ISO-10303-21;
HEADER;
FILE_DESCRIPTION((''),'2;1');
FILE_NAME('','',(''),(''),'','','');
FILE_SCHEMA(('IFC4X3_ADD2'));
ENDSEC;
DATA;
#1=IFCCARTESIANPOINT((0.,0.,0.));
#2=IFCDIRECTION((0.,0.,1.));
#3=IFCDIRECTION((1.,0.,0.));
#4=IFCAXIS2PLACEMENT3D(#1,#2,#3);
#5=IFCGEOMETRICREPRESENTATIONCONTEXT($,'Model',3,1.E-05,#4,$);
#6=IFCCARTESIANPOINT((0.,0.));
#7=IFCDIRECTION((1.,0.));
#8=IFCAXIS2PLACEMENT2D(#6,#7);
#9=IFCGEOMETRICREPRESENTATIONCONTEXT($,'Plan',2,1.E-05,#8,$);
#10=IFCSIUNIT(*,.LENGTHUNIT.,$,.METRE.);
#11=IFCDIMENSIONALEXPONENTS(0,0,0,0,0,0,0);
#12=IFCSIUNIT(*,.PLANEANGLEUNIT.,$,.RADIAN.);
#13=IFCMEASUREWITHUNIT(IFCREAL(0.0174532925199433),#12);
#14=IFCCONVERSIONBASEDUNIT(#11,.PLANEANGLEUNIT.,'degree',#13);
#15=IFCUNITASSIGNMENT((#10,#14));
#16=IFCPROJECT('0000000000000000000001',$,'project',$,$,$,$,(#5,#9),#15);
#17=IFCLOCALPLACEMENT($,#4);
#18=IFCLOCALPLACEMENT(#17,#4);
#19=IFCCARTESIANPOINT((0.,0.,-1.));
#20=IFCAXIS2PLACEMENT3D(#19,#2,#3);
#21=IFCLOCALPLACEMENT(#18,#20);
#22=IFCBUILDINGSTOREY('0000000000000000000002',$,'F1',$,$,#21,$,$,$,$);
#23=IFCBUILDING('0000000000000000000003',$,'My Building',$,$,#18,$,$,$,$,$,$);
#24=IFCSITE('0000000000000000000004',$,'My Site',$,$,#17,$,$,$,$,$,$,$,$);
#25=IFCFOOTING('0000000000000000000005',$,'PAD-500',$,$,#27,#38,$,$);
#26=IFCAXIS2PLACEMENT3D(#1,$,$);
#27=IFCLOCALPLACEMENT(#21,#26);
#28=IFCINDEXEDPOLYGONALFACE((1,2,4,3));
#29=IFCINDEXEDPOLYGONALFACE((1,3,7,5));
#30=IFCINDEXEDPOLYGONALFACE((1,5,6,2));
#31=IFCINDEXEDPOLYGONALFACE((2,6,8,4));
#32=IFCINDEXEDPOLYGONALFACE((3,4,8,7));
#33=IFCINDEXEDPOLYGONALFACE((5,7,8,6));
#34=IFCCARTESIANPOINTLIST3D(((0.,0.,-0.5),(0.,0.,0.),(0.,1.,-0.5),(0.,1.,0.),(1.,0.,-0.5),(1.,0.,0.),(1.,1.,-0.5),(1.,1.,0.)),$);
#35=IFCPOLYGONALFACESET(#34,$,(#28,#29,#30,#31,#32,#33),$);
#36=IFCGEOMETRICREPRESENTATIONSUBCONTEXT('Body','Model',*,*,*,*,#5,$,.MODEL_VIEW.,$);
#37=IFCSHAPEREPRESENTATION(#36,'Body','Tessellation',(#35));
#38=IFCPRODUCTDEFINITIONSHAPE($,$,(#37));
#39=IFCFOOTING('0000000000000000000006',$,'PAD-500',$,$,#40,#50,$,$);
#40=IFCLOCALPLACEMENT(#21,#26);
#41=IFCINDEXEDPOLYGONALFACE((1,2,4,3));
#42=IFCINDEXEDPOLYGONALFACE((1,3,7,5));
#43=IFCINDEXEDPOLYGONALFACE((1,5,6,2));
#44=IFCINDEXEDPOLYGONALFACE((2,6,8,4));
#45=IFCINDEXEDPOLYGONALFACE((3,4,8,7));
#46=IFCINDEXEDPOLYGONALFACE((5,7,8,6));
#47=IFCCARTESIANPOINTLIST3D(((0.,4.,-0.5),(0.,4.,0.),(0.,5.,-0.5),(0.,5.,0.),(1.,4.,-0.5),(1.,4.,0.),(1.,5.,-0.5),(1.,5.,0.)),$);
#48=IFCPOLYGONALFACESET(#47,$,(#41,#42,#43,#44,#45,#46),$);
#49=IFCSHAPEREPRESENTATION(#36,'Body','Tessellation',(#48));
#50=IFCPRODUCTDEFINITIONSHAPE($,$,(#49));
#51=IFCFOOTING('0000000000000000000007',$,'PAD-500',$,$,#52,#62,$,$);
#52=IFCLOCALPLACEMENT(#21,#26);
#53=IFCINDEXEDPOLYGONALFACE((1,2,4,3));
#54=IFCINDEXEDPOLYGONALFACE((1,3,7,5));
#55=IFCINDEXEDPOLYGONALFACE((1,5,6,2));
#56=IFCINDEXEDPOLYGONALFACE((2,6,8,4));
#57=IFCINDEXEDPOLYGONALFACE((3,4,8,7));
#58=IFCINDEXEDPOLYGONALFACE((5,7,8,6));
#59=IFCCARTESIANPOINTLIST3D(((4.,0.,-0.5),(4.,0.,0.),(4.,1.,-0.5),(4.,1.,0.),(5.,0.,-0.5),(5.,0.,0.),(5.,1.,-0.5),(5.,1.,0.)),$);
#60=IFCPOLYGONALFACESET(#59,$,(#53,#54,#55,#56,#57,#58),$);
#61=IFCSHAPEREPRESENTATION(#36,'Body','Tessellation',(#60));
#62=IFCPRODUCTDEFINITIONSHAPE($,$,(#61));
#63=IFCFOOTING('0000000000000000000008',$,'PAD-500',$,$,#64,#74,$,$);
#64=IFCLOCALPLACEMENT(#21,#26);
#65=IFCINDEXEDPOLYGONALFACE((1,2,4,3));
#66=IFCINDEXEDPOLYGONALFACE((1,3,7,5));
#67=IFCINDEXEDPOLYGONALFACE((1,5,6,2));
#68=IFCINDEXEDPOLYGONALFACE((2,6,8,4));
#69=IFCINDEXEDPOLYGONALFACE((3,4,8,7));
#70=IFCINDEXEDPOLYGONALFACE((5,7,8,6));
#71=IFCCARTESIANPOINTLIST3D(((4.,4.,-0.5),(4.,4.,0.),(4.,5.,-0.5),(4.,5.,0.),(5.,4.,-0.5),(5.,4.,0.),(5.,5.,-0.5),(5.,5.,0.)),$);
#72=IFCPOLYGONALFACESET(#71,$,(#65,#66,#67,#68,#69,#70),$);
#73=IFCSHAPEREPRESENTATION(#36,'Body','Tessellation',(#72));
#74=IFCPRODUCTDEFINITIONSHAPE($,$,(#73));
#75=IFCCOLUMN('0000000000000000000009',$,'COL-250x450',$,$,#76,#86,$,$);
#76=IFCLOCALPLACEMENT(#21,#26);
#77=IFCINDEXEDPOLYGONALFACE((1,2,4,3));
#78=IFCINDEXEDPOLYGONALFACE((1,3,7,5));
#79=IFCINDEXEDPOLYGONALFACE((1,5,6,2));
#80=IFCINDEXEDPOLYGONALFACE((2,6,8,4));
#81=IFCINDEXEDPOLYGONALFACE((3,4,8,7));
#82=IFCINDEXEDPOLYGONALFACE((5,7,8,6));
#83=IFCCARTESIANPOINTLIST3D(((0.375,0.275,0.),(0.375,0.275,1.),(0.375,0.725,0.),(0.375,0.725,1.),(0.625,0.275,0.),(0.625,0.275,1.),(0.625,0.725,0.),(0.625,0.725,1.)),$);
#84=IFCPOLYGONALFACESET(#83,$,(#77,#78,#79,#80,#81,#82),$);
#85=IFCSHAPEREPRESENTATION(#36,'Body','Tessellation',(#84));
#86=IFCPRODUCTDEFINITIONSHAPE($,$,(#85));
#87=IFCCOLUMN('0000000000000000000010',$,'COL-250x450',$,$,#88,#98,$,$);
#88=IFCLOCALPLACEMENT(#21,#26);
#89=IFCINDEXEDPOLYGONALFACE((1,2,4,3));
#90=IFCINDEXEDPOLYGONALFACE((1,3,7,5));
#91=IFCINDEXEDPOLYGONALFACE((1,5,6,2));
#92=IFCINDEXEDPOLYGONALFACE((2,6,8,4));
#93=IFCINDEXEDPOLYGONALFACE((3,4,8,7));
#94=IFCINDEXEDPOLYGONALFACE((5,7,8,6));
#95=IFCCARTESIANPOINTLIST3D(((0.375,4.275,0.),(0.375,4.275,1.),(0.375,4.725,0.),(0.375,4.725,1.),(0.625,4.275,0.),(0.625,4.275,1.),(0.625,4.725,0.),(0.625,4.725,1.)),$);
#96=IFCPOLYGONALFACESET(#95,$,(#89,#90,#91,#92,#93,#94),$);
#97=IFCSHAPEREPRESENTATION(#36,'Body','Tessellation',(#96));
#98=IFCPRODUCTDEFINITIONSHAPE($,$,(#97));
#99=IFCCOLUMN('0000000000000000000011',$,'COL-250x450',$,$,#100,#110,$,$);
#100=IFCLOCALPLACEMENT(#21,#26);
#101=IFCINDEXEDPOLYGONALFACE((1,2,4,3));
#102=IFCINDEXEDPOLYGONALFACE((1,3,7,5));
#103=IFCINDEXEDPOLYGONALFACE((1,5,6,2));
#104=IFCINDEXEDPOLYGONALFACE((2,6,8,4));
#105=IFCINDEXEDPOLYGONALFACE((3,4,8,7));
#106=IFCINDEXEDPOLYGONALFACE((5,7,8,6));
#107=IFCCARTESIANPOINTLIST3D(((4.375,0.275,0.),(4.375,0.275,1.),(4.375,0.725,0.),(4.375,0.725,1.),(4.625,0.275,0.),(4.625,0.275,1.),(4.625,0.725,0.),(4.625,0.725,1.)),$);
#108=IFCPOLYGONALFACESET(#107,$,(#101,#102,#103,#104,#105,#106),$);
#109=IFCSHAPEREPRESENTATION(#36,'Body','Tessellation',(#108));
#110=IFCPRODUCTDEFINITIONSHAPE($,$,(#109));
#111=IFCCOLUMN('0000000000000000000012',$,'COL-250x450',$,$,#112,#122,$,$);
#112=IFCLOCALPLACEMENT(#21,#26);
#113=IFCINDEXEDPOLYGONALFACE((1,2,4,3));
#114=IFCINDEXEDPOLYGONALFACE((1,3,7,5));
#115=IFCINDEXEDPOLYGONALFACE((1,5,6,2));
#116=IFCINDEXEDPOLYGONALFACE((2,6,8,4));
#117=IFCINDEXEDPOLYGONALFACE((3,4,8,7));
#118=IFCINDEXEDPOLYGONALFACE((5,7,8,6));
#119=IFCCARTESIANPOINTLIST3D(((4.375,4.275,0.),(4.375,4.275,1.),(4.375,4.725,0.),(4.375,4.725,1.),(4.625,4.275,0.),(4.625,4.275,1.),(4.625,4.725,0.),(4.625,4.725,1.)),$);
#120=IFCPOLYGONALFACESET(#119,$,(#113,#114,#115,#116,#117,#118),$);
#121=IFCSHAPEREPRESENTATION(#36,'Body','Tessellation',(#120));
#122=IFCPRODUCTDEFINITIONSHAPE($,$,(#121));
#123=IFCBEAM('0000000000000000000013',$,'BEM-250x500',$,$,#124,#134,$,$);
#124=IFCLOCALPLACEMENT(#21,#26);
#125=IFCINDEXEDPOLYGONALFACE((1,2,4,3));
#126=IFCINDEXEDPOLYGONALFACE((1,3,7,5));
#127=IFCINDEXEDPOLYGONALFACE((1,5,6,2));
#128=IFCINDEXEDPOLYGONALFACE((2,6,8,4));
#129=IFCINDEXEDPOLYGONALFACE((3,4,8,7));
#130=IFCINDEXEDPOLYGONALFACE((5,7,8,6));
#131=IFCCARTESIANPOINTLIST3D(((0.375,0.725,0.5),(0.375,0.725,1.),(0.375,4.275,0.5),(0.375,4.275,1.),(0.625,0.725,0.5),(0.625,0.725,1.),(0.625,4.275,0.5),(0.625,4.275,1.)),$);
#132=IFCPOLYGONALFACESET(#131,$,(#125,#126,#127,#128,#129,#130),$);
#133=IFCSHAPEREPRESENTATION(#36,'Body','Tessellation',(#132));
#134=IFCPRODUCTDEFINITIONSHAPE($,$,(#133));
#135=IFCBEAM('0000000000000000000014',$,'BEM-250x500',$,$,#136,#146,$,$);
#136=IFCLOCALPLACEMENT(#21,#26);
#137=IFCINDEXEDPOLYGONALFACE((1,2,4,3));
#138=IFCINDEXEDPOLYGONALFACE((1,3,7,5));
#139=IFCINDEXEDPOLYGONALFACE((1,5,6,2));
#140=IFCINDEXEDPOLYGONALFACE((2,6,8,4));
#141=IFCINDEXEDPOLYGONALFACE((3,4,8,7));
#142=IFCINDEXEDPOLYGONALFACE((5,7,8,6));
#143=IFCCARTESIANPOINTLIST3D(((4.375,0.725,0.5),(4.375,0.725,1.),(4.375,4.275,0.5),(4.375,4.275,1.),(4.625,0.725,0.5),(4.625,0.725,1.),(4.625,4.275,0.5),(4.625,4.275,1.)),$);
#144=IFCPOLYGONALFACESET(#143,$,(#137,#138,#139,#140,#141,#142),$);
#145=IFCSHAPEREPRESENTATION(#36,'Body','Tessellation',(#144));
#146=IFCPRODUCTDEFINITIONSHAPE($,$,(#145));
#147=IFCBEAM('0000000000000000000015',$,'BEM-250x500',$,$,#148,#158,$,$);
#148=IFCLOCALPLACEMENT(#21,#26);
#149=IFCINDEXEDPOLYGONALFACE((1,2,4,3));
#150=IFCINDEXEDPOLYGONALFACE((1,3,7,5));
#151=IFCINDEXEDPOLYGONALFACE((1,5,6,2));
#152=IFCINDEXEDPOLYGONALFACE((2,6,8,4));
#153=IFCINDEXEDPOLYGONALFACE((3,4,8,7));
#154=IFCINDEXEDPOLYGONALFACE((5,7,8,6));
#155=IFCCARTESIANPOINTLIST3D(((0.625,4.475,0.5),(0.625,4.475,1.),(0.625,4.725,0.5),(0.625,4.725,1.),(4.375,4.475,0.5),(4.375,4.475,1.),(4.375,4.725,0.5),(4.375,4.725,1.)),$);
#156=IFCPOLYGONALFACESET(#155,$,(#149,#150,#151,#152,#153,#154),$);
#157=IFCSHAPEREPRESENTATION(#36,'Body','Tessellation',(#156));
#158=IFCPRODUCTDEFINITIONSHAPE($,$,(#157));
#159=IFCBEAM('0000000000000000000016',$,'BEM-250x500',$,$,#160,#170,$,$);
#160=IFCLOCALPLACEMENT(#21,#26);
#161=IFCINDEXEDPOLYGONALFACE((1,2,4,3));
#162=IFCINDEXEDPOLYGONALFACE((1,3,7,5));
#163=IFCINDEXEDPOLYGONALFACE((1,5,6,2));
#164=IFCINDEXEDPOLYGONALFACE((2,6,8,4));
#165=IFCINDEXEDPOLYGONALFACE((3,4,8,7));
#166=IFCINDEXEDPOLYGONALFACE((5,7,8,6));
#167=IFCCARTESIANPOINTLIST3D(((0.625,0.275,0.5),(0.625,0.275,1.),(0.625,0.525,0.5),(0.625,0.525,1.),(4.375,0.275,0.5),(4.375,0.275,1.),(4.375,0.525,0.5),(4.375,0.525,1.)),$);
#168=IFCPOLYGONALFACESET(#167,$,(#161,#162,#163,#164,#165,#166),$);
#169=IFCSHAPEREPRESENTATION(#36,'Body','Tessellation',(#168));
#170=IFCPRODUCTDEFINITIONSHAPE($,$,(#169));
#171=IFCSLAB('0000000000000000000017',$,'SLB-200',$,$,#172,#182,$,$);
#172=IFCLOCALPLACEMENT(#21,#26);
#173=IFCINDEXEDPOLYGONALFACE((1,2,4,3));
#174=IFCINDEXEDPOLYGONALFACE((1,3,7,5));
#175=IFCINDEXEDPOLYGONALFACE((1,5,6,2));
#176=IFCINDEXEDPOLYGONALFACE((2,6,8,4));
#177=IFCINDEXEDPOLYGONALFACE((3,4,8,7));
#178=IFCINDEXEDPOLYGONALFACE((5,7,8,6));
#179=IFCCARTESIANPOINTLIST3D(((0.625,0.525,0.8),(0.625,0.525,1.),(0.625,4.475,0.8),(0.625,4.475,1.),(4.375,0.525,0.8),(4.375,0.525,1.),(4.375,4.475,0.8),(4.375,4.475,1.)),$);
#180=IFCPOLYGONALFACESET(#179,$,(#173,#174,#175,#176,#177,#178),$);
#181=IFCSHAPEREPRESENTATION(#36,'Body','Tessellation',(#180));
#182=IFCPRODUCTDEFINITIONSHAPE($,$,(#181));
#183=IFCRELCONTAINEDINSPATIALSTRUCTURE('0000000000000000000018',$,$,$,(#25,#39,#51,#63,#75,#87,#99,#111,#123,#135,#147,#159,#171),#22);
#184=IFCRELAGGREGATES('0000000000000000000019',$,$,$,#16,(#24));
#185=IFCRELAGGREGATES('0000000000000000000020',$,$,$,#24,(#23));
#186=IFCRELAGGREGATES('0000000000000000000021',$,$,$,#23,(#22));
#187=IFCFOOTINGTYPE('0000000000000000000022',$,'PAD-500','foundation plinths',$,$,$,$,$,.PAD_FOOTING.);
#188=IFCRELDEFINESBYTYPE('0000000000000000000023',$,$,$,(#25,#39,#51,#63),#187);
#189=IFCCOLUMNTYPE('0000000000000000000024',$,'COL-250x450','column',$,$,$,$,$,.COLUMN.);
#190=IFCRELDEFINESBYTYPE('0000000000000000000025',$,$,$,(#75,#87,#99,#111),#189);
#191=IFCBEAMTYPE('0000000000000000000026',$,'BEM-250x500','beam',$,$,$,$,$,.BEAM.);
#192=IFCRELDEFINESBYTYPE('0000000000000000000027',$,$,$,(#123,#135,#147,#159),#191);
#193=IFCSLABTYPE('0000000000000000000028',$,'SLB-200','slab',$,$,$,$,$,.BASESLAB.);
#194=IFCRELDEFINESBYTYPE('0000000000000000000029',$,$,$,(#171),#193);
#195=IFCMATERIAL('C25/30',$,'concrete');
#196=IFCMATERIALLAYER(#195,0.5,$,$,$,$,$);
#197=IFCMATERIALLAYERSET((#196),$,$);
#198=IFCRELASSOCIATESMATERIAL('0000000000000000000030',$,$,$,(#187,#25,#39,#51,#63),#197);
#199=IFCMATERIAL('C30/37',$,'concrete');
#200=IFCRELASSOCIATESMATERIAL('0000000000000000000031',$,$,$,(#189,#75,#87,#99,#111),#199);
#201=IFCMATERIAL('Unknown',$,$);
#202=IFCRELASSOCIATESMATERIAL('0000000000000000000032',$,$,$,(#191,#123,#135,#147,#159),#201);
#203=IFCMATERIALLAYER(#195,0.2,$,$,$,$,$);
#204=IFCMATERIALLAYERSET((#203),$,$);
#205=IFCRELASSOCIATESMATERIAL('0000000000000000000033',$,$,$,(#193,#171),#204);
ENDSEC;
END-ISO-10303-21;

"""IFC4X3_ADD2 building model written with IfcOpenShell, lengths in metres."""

from ifc_helpers import new_model, entity, si_unit, converted_unit, frame, origin_with_axes, origin_2d_with_axis, place, context, subcontext, project, spatial, indexed_curve, rectangle, outline, extrude, material, layer, layer_set, layer_usage, material_profile, profile_set, profile_usage, type_object, element, save


model = new_model("IFC4X3_ADD2")

# Units and contexts
model_context = context("Model", 3, precision=1e-05, world=origin_with_axes())
plan_context = context("Plan", 2, precision=1e-05, world=origin_2d_with_axis())
body_context = subcontext(model_context, "Body", "Model", "MODEL_VIEW")
ifc_project = project(units=[si_unit("LENGTHUNIT", "METRE"), converted_unit("PLANEANGLEUNIT", "degree", entity("IfcReal", 0.0174532925199433), si_unit("PLANEANGLEUNIT", "RADIAN"), dimensions=[0, 0, 0, 0, 0, 0, 0])], contexts=[model_context, plan_context])

# Site, building, storey
site_placement = place(None, origin_with_axes())
site = spatial("IfcSite", under=ifc_project, at=site_placement, Name="My Site")
building_placement = place(site_placement, origin_with_axes())
building = spatial("IfcBuilding", under=site, at=building_placement, Name="My Building")
storey_placement = place(building_placement, frame((0.0, 0.0, -1.0), z_axis=(0.0, 0.0, 1.0), x_axis=(1.0, 0.0, 0.0)))
storey = spatial("IfcBuildingStorey", under=building, at=storey_placement, Name="F1")

# Footings
ifc_material_1 = material(Name="C25/30", Category="concrete")
ifc_layer_1 = layer(ifc_material_1, 0.5)
ifc_layer_set_1 = layer_set([ifc_layer_1])
ifc_layer_usage_1 = layer_usage(ifc_layer_set_1, "AXIS3", "POSITIVE", -0.5)
footing_type = type_object("IfcFootingType", Name="PAD-500", Description="foundation plinths", PredefinedType="PAD_FOOTING", material=ifc_layer_set_1)
footing_1_placement = place(storey_placement, origin_with_axes())
element("IfcFooting", 1, at=footing_1_placement, inside=storey, type_object=footing_type, material=ifc_layer_usage_1, Name="PAD-500", context=body_context, shape_type="SweptSolid", body=[
    extrude(outline(indexed_curve([(0.0, 0.0), (0.0, 1.0), (1.0, 1.0), (1.0, 0.0), (0.0, 0.0)])), frame((0.0, 0.0, -0.5), z_axis=(0.0, 0.0, 1.0), x_axis=(1.0, 0.0, 0.0)), (0.0, 0.0, 1.0), 0.5),
])
ifc_layer_usage_2 = layer_usage(ifc_layer_set_1, "AXIS3", "POSITIVE", -0.5)
footing_2_placement = place(storey_placement, frame((0.0, 4.0, 0.0), z_axis=(0.0, 0.0, 1.0), x_axis=(1.0, 0.0, 0.0)))
element("IfcFooting", 2, at=footing_2_placement, inside=storey, type_object=footing_type, material=ifc_layer_usage_2, Name="PAD-500", context=body_context, shape_type="SweptSolid", body=[
    extrude(outline(indexed_curve([(0.0, 0.0), (0.0, 1.0), (1.0, 1.0), (1.0, 0.0), (0.0, 0.0)])), frame((0.0, 0.0, -0.5), z_axis=(0.0, 0.0, 1.0), x_axis=(1.0, 0.0, 0.0)), (0.0, 0.0, 1.0), 0.5),
])
ifc_layer_usage_3 = layer_usage(ifc_layer_set_1, "AXIS3", "POSITIVE", -0.5)
footing_3_placement = place(storey_placement, frame((4.0, 0.0, 0.0), z_axis=(0.0, 0.0, 1.0), x_axis=(1.0, 0.0, 0.0)))
element("IfcFooting", 3, at=footing_3_placement, inside=storey, type_object=footing_type, material=ifc_layer_usage_3, Name="PAD-500", context=body_context, shape_type="SweptSolid", body=[
    extrude(outline(indexed_curve([(0.0, 0.0), (0.0, 1.0), (1.0, 1.0), (1.0, 0.0), (0.0, 0.0)])), frame((0.0, 0.0, -0.5), z_axis=(0.0, 0.0, 1.0), x_axis=(1.0, 0.0, 0.0)), (0.0, 0.0, 1.0), 0.5),
])
ifc_layer_usage_4 = layer_usage(ifc_layer_set_1, "AXIS3", "POSITIVE", -0.5)
footing_4_placement = place(storey_placement, frame((4.0, 4.0, 0.0), z_axis=(0.0, 0.0, 1.0), x_axis=(1.0, 0.0, 0.0)))
element("IfcFooting", 4, at=footing_4_placement, inside=storey, type_object=footing_type, material=ifc_layer_usage_4, Name="PAD-500", context=body_context, shape_type="SweptSolid", body=[
    extrude(outline(indexed_curve([(0.0, 0.0), (0.0, 1.0), (1.0, 1.0), (1.0, 0.0), (0.0, 0.0)])), frame((0.0, 0.0, -0.5), z_axis=(0.0, 0.0, 1.0), x_axis=(1.0, 0.0, 0.0)), (0.0, 0.0, 1.0), 0.5),
])

# Columns
ifc_material_2 = material(Name="C30/37", Category="concrete")
ifc_material_profile_1 = material_profile(ifc_material_2, rectangle(XDim=0.25, YDim=0.45))
ifc_profile_set_1 = profile_set([ifc_material_profile_1])
ifc_profile_usage_1 = profile_usage(ifc_profile_set_1, cardinal=2)
column_type = type_object("IfcColumnType", Name="COL-250x450", Description="column", PredefinedType="COLUMN", material=ifc_profile_set_1)
column_1_placement = place(storey_placement, frame((0.5, 0.275, 0.0), z_axis=(0.0, 0.0, 1.0), x_axis=(1.0, 0.0, 0.0)))
element("IfcColumn", 5, at=column_1_placement, inside=storey, type_object=column_type, material=ifc_profile_usage_1, Name="COL-250x450", context=body_context, shape_type="SweptSolid", body=[
    extrude(rectangle(XDim=0.25, YDim=0.45), frame((0.0, 0.225, 0.0), z_axis=(0.0, 0.0, 1.0), x_axis=(1.0, 0.0, 0.0)), (0.0, 0.0, 1.0), 1.0),
])
ifc_profile_usage_2 = profile_usage(ifc_profile_set_1, cardinal=2)
column_2_placement = place(storey_placement, frame((0.5, 4.275, 0.0), z_axis=(0.0, 0.0, 1.0), x_axis=(1.0, 0.0, 0.0)))
element("IfcColumn", 6, at=column_2_placement, inside=storey, type_object=column_type, material=ifc_profile_usage_2, Name="COL-250x450", context=body_context, shape_type="SweptSolid", body=[
    extrude(rectangle(XDim=0.25, YDim=0.45), frame((0.0, 0.225, 0.0), z_axis=(0.0, 0.0, 1.0), x_axis=(1.0, 0.0, 0.0)), (0.0, 0.0, 1.0), 1.0),
])
ifc_profile_usage_3 = profile_usage(ifc_profile_set_1, cardinal=2)
column_3_placement = place(storey_placement, frame((4.5, 0.275, 0.0), z_axis=(0.0, 0.0, 1.0), x_axis=(1.0, 0.0, 0.0)))
element("IfcColumn", 7, at=column_3_placement, inside=storey, type_object=column_type, material=ifc_profile_usage_3, Name="COL-250x450", context=body_context, shape_type="SweptSolid", body=[
    extrude(rectangle(XDim=0.25, YDim=0.45), frame((0.0, 0.225, 0.0), z_axis=(0.0, 0.0, 1.0), x_axis=(1.0, 0.0, 0.0)), (0.0, 0.0, 1.0), 1.0),
])
ifc_profile_usage_4 = profile_usage(ifc_profile_set_1, cardinal=2)
column_4_placement = place(storey_placement, frame((4.5, 4.275, 0.0), z_axis=(0.0, 0.0, 1.0), x_axis=(1.0, 0.0, 0.0)))
element("IfcColumn", 8, at=column_4_placement, inside=storey, type_object=column_type, material=ifc_profile_usage_4, Name="COL-250x450", context=body_context, shape_type="SweptSolid", body=[
    extrude(rectangle(XDim=0.25, YDim=0.45), frame((0.0, 0.225, 0.0), z_axis=(0.0, 0.0, 1.0), x_axis=(1.0, 0.0, 0.0)), (0.0, 0.0, 1.0), 1.0),
])

# Beams
ifc_material_3 = material(Name="Unknown")
ifc_material_profile_2 = material_profile(ifc_material_3, rectangle(XDim=0.25, YDim=0.5))
ifc_profile_set_2 = profile_set([ifc_material_profile_2])
ifc_profile_usage_5 = profile_usage(ifc_profile_set_2, cardinal=8)
beam_type = type_object("IfcBeamType", Name="BEM-250x500", Description="beam", PredefinedType="BEAM", material=ifc_profile_set_2)
beam_1_placement = place(storey_placement, frame((0.5, 0.725, 1.0), z_axis=(0.0, 1.0, 0.0), x_axis=(-1.0, 0.0, 0.0)))
element("IfcBeam", 9, at=beam_1_placement, inside=storey, type_object=beam_type, material=ifc_profile_usage_5, Name="BEM-250x500", context=body_context, shape_type="SweptSolid", body=[
    extrude(rectangle(XDim=0.25, YDim=0.5), frame((0.0, -0.25, 0.0), z_axis=(0.0, 0.0, 1.0), x_axis=(1.0, 0.0, 0.0)), (0.0, 0.0, 1.0), 3.55),
])
ifc_profile_usage_6 = profile_usage(ifc_profile_set_2, cardinal=8)
beam_2_placement = place(storey_placement, frame((4.5, 0.725, 1.0), z_axis=(0.0, 1.0, 0.0), x_axis=(-1.0, 0.0, 0.0)))
element("IfcBeam", 10, at=beam_2_placement, inside=storey, type_object=beam_type, material=ifc_profile_usage_6, Name="BEM-250x500", context=body_context, shape_type="SweptSolid", body=[
    extrude(rectangle(XDim=0.25, YDim=0.5), frame((0.0, -0.25, 0.0), z_axis=(0.0, 0.0, 1.0), x_axis=(1.0, 0.0, 0.0)), (0.0, 0.0, 1.0), 3.55),
])
ifc_profile_usage_7 = profile_usage(ifc_profile_set_2, cardinal=8)
beam_3_placement = place(storey_placement, frame((4.375, 4.6, 1.0), z_axis=(-1.0, 0.0, 0.0), x_axis=(0.0, -1.0, 0.0)))
element("IfcBeam", 11, at=beam_3_placement, inside=storey, type_object=beam_type, material=ifc_profile_usage_7, Name="BEM-250x500", context=body_context, shape_type="SweptSolid", body=[
    extrude(rectangle(XDim=0.25, YDim=0.5), frame((0.0, -0.25, 0.0), z_axis=(0.0, 0.0, 1.0), x_axis=(1.0, 0.0, 0.0)), (0.0, 0.0, 1.0), 3.75),
])
ifc_profile_usage_8 = profile_usage(ifc_profile_set_2, cardinal=8)
beam_4_placement = place(storey_placement, frame((4.375, 0.4, 1.0), z_axis=(-1.0, 0.0, 0.0), x_axis=(0.0, -1.0, 0.0)))
element("IfcBeam", 12, at=beam_4_placement, inside=storey, type_object=beam_type, material=ifc_profile_usage_8, Name="BEM-250x500", context=body_context, shape_type="SweptSolid", body=[
    extrude(rectangle(XDim=0.25, YDim=0.5), frame((0.0, -0.25, 0.0), z_axis=(0.0, 0.0, 1.0), x_axis=(1.0, 0.0, 0.0)), (0.0, 0.0, 1.0), 3.75),
])

# Slab
ifc_layer_2 = layer(ifc_material_1, 0.2)
ifc_layer_set_2 = layer_set([ifc_layer_2])
ifc_layer_usage_5 = layer_usage(ifc_layer_set_2, "AXIS3", "POSITIVE", -0.2)
slab_type_1 = type_object("IfcSlabType", Name="SLB-200", Description="slab", PredefinedType="BASESLAB", material=ifc_layer_set_2)
slab_1_placement = place(storey_placement, frame((0.625, 0.525, 1.0), z_axis=(0.0, 0.0, 1.0), x_axis=(1.0, 0.0, 0.0)))
element("IfcSlab", 13, at=slab_1_placement, inside=storey, type_object=slab_type_1, material=ifc_layer_usage_5, Name="SLB-200", context=body_context, shape_type="SweptSolid", body=[
    extrude(outline(indexed_curve([(0.0, 0.0), (0.0, 3.95), (3.75, 3.95), (3.75, 0.0), (0.0, 0.0)])), frame((0.0, 0.0, -0.2), z_axis=(0.0, 0.0, 1.0), x_axis=(1.0, 0.0, 0.0)), (0.0, 0.0, 1.0), 0.2),
])

save(model, "model.ifc")
